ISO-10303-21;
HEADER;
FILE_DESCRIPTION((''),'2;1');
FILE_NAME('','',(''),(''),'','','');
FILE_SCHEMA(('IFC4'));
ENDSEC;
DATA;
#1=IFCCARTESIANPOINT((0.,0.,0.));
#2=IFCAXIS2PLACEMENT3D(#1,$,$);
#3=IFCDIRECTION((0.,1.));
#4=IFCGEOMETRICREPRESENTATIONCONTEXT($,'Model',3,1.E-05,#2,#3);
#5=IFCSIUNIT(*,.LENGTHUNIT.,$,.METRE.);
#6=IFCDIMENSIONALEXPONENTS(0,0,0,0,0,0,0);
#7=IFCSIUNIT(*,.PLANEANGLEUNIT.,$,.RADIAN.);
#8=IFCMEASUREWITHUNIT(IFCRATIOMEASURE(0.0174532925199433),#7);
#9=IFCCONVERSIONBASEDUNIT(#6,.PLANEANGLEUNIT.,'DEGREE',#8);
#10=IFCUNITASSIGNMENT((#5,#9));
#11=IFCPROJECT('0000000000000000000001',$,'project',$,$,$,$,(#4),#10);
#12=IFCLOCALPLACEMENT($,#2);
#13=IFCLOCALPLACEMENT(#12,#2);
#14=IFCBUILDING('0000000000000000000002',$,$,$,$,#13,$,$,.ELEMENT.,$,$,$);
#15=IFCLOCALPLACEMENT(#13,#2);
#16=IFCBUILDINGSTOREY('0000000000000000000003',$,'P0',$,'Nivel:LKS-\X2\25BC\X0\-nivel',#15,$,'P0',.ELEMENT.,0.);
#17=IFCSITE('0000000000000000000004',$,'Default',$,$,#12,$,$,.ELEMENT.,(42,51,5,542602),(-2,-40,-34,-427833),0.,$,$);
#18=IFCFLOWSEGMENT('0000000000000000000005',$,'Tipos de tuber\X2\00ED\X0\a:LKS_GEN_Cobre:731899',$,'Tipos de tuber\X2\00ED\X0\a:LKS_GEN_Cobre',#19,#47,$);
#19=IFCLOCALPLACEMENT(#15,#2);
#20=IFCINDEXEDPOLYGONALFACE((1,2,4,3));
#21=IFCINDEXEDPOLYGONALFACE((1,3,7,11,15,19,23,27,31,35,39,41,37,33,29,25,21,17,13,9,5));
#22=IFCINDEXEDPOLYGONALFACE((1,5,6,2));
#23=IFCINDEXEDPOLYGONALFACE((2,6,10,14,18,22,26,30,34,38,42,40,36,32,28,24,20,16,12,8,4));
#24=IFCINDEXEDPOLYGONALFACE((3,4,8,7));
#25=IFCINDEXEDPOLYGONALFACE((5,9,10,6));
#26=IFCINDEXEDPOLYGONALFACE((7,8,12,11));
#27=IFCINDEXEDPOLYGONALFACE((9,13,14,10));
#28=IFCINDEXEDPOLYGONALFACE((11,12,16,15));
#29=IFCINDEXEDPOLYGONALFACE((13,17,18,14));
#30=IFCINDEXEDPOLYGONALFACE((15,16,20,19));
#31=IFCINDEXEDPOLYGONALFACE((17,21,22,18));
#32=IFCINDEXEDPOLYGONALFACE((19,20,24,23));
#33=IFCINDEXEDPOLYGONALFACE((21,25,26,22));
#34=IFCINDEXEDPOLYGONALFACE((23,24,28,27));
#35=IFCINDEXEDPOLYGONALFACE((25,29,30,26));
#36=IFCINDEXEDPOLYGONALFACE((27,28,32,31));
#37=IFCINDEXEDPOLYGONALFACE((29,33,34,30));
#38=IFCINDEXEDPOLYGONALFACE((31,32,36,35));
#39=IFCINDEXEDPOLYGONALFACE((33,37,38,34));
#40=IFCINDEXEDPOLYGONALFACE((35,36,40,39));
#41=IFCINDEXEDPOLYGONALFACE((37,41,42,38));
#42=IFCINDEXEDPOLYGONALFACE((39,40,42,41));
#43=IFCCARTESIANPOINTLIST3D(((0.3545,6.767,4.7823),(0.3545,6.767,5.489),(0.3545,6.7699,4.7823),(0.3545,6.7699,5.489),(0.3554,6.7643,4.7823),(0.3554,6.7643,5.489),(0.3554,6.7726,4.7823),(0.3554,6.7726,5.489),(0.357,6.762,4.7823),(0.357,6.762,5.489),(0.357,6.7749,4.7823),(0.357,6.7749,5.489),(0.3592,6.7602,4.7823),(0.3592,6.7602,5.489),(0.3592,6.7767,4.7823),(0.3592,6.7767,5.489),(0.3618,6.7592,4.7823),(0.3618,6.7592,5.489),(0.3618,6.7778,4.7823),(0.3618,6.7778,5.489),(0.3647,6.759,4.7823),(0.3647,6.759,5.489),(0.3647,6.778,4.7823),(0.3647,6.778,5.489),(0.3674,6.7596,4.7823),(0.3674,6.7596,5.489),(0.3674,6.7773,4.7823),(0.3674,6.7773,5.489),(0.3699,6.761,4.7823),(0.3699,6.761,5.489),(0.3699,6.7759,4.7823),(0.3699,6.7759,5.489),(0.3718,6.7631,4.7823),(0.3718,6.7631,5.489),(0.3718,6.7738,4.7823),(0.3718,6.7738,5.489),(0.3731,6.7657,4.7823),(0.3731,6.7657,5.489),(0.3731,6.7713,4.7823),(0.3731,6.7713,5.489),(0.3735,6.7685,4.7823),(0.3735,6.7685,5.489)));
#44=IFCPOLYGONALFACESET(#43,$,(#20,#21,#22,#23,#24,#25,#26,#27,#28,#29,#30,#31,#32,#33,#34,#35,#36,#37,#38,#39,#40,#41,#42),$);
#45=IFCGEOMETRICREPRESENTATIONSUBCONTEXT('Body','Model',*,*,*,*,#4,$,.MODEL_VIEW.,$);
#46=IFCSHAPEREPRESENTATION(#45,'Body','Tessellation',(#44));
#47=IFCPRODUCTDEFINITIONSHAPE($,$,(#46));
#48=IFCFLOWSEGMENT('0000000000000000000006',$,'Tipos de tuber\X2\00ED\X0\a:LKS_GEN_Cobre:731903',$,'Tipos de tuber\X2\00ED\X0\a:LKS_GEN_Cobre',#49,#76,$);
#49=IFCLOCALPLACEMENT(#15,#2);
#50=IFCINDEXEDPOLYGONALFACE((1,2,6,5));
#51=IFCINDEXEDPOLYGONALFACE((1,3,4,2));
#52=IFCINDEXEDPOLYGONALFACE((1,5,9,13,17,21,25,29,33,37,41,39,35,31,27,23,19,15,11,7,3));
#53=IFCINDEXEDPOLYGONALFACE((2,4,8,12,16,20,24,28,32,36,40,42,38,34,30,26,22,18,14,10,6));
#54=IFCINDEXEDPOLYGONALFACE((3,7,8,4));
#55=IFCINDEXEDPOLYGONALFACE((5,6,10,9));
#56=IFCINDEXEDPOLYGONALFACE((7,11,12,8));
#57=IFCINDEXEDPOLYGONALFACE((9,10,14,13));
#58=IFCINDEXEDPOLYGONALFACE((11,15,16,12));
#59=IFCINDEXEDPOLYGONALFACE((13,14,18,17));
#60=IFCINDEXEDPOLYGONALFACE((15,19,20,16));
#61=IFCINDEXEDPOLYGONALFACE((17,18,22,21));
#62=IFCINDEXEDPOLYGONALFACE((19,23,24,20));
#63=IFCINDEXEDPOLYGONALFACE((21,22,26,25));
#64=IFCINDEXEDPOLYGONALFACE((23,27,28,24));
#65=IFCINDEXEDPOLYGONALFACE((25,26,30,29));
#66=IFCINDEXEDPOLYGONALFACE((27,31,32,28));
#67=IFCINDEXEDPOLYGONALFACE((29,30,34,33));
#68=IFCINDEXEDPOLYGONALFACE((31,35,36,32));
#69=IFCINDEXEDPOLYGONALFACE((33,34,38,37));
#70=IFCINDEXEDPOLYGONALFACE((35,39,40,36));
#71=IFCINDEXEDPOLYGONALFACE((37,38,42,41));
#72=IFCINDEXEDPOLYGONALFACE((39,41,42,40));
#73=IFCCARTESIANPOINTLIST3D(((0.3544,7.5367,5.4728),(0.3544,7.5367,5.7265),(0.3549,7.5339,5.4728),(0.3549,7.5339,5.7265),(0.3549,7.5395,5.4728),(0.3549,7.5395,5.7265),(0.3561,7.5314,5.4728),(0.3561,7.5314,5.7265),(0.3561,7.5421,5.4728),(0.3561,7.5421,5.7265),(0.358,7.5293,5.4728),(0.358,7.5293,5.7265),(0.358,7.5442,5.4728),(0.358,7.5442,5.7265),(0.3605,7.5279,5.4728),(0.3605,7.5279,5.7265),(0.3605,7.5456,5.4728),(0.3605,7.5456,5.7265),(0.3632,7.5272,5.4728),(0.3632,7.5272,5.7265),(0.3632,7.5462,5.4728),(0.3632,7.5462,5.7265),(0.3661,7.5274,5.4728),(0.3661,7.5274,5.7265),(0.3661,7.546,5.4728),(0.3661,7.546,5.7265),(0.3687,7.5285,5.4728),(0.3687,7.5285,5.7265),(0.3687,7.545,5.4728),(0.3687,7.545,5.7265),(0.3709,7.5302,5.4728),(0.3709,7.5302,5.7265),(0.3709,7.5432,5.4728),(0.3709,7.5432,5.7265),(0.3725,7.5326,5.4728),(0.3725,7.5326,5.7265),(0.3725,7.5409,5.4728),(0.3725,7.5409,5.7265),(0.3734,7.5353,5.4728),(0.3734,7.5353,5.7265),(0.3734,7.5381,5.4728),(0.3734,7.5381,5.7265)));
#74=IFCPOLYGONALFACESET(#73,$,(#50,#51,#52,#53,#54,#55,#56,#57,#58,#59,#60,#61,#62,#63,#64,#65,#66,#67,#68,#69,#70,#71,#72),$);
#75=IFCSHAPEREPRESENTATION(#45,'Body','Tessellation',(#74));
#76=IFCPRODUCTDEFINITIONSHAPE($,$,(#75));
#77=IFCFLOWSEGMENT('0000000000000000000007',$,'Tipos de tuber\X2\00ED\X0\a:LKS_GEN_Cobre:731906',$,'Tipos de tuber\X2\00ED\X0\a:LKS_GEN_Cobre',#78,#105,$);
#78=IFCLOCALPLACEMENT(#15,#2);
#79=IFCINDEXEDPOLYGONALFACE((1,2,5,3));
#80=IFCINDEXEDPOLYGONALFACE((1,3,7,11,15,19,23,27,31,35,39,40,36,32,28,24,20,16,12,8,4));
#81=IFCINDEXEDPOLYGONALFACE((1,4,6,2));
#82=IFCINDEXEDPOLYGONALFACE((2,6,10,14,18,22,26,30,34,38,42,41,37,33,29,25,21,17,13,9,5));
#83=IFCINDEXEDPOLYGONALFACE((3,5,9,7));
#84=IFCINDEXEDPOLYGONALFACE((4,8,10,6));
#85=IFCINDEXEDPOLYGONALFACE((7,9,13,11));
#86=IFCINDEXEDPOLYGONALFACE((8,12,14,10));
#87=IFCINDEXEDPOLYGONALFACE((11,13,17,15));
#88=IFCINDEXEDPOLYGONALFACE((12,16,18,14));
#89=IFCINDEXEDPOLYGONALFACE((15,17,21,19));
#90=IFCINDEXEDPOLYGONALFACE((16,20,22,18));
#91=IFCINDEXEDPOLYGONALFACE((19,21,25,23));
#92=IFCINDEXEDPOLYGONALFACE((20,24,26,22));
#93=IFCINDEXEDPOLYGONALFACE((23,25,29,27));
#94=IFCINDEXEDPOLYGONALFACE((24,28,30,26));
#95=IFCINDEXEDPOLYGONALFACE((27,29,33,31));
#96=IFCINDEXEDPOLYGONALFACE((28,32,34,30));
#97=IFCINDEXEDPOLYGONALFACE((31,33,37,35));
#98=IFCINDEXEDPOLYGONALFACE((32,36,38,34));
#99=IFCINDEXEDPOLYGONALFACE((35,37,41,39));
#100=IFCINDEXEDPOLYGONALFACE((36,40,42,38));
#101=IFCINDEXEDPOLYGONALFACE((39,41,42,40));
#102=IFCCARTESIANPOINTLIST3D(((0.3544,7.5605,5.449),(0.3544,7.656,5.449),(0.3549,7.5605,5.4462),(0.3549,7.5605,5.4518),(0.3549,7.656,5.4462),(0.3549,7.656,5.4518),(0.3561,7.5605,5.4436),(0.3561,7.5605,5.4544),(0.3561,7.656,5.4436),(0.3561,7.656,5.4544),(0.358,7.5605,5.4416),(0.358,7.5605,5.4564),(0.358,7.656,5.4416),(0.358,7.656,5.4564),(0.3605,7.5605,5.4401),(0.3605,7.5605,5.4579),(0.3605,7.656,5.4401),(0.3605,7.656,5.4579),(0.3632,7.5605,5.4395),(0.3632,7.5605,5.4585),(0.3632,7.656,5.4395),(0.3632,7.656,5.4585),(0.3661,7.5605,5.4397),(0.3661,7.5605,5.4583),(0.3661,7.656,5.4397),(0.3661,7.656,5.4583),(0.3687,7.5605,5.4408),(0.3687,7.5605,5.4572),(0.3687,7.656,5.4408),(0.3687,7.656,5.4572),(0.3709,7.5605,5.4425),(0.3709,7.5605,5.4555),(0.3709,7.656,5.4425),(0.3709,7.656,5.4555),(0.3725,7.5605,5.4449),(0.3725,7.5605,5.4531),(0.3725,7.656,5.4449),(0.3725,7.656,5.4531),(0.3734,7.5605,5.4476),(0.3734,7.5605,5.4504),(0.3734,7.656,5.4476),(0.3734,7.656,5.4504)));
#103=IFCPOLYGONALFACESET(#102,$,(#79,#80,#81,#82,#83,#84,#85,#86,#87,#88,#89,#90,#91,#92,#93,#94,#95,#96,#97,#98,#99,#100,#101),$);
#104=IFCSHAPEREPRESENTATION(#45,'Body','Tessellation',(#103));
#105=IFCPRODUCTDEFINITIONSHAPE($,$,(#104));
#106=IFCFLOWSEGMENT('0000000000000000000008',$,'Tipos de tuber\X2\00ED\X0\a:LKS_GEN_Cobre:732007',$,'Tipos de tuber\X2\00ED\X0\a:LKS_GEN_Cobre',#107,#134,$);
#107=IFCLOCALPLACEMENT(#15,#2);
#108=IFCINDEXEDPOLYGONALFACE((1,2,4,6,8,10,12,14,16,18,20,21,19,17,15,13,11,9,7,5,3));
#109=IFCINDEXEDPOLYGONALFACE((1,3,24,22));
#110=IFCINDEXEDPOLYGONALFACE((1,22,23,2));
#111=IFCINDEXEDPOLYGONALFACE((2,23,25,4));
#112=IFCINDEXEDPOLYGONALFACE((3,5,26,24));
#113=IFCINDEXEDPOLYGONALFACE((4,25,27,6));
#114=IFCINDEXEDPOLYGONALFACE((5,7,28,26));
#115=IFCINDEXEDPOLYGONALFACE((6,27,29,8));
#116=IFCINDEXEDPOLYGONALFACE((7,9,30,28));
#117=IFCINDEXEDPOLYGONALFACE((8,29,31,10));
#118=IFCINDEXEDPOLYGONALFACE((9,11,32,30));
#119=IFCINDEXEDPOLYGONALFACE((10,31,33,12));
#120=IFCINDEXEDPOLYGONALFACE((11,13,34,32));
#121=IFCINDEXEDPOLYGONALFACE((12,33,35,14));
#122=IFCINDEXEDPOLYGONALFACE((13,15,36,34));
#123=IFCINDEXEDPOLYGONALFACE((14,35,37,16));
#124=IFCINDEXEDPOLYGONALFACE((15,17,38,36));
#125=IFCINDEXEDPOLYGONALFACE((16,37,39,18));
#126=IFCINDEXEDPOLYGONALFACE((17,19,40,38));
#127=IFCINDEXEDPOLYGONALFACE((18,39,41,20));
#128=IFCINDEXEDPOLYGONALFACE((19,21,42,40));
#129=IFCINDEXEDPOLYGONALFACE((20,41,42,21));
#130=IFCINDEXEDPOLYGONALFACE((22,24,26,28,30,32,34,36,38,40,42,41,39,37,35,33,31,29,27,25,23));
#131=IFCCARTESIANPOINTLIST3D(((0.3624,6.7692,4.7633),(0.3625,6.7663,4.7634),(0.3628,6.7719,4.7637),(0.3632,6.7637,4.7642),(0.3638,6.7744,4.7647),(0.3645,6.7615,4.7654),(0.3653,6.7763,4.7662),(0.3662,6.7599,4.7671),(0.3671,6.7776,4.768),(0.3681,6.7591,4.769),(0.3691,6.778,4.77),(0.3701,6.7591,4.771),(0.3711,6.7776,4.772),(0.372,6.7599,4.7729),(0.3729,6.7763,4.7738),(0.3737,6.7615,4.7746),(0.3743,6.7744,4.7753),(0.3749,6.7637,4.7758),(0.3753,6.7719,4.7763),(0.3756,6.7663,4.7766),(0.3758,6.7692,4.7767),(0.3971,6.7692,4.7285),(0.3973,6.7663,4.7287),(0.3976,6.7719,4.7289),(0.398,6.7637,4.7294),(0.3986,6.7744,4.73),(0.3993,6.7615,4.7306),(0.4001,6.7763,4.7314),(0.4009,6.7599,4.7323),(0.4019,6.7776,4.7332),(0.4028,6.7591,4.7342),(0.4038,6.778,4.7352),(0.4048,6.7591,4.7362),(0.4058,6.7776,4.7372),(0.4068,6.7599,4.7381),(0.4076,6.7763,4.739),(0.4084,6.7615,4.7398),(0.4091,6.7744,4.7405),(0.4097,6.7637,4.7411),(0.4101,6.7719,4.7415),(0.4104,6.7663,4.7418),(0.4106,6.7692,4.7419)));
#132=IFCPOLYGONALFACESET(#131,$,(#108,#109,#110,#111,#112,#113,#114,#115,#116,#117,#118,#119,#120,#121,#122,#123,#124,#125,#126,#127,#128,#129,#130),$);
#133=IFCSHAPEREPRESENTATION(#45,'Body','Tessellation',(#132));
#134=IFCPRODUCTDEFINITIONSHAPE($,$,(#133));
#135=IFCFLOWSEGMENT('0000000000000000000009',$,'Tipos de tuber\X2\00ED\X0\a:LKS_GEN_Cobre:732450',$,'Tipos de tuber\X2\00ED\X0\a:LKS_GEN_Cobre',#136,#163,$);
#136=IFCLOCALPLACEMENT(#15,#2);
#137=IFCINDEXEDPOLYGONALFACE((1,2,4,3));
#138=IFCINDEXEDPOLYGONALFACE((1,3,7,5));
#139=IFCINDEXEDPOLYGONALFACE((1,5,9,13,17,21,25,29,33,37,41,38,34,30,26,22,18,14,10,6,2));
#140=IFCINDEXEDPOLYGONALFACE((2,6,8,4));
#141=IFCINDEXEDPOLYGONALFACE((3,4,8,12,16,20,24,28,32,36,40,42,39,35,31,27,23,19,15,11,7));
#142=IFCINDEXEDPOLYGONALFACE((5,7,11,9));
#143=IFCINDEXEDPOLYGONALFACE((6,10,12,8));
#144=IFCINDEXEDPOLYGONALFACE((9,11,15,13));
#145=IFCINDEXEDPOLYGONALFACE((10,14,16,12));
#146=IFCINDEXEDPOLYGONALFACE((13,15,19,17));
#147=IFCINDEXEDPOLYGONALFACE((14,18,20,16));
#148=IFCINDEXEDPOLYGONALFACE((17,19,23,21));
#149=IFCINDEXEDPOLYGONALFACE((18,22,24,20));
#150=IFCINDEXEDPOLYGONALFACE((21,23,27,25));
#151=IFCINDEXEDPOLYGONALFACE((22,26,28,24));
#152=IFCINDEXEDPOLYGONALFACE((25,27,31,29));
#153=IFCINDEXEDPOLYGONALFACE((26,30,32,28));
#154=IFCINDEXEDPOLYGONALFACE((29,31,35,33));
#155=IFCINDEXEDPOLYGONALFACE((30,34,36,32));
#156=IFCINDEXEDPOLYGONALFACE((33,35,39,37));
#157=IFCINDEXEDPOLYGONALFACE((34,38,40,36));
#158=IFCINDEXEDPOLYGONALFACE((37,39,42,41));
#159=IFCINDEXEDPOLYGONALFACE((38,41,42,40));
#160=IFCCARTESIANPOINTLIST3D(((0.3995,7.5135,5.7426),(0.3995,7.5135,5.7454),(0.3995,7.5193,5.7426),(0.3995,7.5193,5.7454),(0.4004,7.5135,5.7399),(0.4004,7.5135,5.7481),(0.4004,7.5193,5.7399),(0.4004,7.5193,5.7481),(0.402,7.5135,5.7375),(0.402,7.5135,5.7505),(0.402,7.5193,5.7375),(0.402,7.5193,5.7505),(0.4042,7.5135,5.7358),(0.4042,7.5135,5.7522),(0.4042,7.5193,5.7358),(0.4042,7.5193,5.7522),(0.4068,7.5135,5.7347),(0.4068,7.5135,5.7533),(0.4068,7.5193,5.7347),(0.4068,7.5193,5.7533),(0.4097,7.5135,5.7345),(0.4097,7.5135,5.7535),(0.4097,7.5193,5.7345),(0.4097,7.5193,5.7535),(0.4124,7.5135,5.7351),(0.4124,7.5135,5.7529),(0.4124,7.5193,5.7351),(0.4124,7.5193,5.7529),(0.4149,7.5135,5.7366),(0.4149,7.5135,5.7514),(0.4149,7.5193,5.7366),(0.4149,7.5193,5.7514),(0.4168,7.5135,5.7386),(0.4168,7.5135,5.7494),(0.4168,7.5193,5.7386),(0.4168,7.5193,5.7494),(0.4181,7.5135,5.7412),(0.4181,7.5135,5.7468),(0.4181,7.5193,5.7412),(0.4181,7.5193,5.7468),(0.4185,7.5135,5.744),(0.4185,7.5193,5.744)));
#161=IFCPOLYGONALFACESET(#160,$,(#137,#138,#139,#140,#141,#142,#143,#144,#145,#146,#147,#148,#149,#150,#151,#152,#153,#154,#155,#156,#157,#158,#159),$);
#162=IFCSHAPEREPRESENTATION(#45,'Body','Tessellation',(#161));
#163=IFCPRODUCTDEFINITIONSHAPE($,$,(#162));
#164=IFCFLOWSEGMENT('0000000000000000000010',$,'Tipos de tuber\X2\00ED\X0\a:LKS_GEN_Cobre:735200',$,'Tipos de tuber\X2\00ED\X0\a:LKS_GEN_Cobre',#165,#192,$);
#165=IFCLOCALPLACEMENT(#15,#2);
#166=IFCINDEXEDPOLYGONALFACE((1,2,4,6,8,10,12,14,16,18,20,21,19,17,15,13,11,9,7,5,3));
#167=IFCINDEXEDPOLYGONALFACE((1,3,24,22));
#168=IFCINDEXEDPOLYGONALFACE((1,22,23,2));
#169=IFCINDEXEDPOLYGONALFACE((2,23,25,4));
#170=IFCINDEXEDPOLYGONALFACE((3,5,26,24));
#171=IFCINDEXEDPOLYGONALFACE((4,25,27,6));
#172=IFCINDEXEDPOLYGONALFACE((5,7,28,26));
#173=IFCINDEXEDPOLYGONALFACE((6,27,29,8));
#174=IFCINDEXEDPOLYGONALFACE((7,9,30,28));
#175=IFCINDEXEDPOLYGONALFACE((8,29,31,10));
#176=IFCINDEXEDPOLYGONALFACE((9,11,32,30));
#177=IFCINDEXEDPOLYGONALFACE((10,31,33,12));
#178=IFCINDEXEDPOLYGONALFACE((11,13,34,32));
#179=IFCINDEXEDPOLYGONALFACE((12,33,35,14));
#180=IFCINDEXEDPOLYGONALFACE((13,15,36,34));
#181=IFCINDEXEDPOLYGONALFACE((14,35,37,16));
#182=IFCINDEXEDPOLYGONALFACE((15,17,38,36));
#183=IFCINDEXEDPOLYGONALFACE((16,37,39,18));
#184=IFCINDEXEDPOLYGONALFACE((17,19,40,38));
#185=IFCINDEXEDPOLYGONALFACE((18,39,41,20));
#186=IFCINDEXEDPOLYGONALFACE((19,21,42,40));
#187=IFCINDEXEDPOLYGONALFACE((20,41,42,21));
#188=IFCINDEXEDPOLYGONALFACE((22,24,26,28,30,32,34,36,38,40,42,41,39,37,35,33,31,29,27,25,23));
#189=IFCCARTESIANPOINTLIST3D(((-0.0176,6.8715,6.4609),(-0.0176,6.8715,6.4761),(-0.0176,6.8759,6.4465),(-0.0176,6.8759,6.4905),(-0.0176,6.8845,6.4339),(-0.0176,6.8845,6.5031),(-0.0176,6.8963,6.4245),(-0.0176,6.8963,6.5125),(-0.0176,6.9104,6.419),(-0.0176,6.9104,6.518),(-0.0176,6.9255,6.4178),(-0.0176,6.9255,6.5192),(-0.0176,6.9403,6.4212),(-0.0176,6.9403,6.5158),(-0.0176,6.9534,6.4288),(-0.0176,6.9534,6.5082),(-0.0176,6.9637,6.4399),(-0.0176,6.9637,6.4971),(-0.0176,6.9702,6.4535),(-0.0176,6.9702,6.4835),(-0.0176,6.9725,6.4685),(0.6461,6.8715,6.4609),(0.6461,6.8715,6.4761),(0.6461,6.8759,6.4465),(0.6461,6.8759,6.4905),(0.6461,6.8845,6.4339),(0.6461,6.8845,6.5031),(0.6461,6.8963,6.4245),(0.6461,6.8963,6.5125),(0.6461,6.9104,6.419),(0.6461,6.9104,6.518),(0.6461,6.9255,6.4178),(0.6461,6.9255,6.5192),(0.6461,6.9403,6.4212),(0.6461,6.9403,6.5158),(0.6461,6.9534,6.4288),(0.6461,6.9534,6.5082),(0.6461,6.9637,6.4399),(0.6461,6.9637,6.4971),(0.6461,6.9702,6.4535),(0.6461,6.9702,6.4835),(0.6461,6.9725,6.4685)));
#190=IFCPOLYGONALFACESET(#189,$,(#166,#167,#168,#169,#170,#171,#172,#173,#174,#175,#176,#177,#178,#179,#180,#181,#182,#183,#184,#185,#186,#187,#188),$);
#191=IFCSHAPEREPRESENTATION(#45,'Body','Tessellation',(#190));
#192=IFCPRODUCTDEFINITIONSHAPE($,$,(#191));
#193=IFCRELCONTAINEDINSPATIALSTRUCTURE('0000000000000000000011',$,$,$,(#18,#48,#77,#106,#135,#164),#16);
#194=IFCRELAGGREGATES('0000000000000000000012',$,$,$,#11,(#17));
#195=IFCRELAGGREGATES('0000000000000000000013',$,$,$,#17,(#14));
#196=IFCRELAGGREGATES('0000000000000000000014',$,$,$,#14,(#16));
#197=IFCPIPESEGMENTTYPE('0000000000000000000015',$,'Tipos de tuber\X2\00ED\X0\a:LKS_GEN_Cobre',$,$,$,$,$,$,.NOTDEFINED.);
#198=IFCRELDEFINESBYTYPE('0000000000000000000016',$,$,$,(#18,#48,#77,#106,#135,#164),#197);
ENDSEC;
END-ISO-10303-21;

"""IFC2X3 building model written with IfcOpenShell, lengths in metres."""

from ifc_helpers import new_model, entity, si_unit, converted_unit, direction, frame, frame_2d, origin, origin_2d_with_axis, place, context, subcontext, project, spatial, circle, extrude, type_object, element, save


model = new_model("IFC2X3")

# Units and contexts
model_context = context("Model", 3, precision=1e-05, world=origin(), true_north=direction((0.0, 1.0)))
body_context = subcontext(model_context, "Body", "Model", "MODEL_VIEW")
ifc_project = project(units=[si_unit("LENGTHUNIT", "METRE"), converted_unit("PLANEANGLEUNIT", "DEGREE", entity("IfcRatioMeasure", 0.0174532925199433), si_unit("PLANEANGLEUNIT", "RADIAN"), dimensions=[0, 0, 0, 0, 0, 0, 0])], contexts=[model_context])

# Site, building, storey
site_placement = place(None, origin())
site = spatial("IfcSite", under=ifc_project, at=site_placement, Name="Default", CompositionType="ELEMENT", RefLatitude=(42, 51, 5, 542602), RefLongitude=(-2, -40, -34, -427833), RefElevation=0.0)
building_placement = place(site_placement, origin())
building = spatial("IfcBuilding", under=site, at=building_placement, CompositionType="ELEMENT")
storey_placement = place(building_placement, origin())
storey = spatial("IfcBuildingStorey", under=building, at=storey_placement, Name="P0", ObjectType="Nivel:LKS-▼-nivel", LongName="P0", CompositionType="ELEMENT", Elevation=0.0)

# Flow segments
pipe_segment_type = type_object("IfcPipeSegmentType", Name="Tipos de tubería:LKS_GEN_Cobre", PredefinedType="NOTDEFINED")
flow_segment_1_placement = place(storey_placement, origin())
element("IfcFlowSegment", 1, at=flow_segment_1_placement, inside=storey, type_object=pipe_segment_type, Name="Tipos de tubería:LKS_GEN_Cobre:731899", ObjectType="Tipos de tubería:LKS_GEN_Cobre", context=body_context, shape_type="SweptSolid", body=[
    extrude(circle(Radius=0.0095, at=origin_2d_with_axis()), frame((0.364, 6.7685, 4.7823)), (0.0, 0.0, 1.0), 0.7067),
])
flow_segment_2_placement = place(storey_placement, origin())
element("IfcFlowSegment", 2, at=flow_segment_2_placement, inside=storey, type_object=pipe_segment_type, Name="Tipos de tubería:LKS_GEN_Cobre:731903", ObjectType="Tipos de tubería:LKS_GEN_Cobre", context=body_context, shape_type="SweptSolid", body=[
    extrude(circle(Radius=0.0095, at=frame_2d((0.0, 0.0), x_axis=(1.0, 0.0))), frame((0.364, 7.5367, 5.4728), z_axis=(0.0, 0.0, 1.0), x_axis=(-1.0, 0.0, 0.0)), (0.0, 0.0, 1.0), 0.2537),
])
flow_segment_3_placement = place(storey_placement, origin())
element("IfcFlowSegment", 3, at=flow_segment_3_placement, inside=storey, type_object=pipe_segment_type, Name="Tipos de tubería:LKS_GEN_Cobre:731906", ObjectType="Tipos de tubería:LKS_GEN_Cobre", context=body_context, shape_type="SweptSolid", body=[
    extrude(circle(Radius=0.0095, at=frame_2d((0.0, 0.0), x_axis=(1.0, 0.0))), frame((0.364, 7.5605, 5.449), z_axis=(0.0, 1.0, 0.0), x_axis=(-1.0, 0.0, 0.0)), (0.0, 0.0, 1.0), 0.0955),
])
flow_segment_4_placement = place(storey_placement, origin())
element("IfcFlowSegment", 4, at=flow_segment_4_placement, inside=storey, type_object=pipe_segment_type, Name="Tipos de tubería:LKS_GEN_Cobre:732007", ObjectType="Tipos de tubería:LKS_GEN_Cobre", context=body_context, shape_type="SweptSolid", body=[
    extrude(circle(Radius=0.0095, at=origin_2d_with_axis()), frame((0.3691, 6.7685, 4.77), z_axis=(0.707109, 0.0, -0.707105), x_axis=(0.0, 1.0, 0.0)), (0.0, 0.0, 1.0), 0.0492),
])
flow_segment_5_placement = place(storey_placement, origin())
element("IfcFlowSegment", 5, at=flow_segment_5_placement, inside=storey, type_object=pipe_segment_type, Name="Tipos de tubería:LKS_GEN_Cobre:732450", ObjectType="Tipos de tubería:LKS_GEN_Cobre", context=body_context, shape_type="SweptSolid", body=[
    extrude(circle(Radius=0.0095, at=origin_2d_with_axis()), frame((0.409, 7.5135, 5.744), z_axis=(0.0, 1.0, 0.0), x_axis=(1.0, 0.0, 0.0)), (0.0, 0.0, 1.0), 0.0058),
])
flow_segment_6_placement = place(storey_placement, origin())
element("IfcFlowSegment", 6, at=flow_segment_6_placement, inside=storey, type_object=pipe_segment_type, Name="Tipos de tubería:LKS_GEN_Cobre:735200", ObjectType="Tipos de tubería:LKS_GEN_Cobre", context=body_context, shape_type="SweptSolid", body=[
    extrude(circle(Radius=0.0508, at=frame_2d((0.0, 0.0), x_axis=(1.0, 0.0))), frame((-0.0176, 6.9217, 6.4685), z_axis=(1.0, 0.0, 0.0), x_axis=(0.0, 1.0, 0.0)), (0.0, 0.0, 1.0), 0.6637),
])

save(model, "model.ifc")
